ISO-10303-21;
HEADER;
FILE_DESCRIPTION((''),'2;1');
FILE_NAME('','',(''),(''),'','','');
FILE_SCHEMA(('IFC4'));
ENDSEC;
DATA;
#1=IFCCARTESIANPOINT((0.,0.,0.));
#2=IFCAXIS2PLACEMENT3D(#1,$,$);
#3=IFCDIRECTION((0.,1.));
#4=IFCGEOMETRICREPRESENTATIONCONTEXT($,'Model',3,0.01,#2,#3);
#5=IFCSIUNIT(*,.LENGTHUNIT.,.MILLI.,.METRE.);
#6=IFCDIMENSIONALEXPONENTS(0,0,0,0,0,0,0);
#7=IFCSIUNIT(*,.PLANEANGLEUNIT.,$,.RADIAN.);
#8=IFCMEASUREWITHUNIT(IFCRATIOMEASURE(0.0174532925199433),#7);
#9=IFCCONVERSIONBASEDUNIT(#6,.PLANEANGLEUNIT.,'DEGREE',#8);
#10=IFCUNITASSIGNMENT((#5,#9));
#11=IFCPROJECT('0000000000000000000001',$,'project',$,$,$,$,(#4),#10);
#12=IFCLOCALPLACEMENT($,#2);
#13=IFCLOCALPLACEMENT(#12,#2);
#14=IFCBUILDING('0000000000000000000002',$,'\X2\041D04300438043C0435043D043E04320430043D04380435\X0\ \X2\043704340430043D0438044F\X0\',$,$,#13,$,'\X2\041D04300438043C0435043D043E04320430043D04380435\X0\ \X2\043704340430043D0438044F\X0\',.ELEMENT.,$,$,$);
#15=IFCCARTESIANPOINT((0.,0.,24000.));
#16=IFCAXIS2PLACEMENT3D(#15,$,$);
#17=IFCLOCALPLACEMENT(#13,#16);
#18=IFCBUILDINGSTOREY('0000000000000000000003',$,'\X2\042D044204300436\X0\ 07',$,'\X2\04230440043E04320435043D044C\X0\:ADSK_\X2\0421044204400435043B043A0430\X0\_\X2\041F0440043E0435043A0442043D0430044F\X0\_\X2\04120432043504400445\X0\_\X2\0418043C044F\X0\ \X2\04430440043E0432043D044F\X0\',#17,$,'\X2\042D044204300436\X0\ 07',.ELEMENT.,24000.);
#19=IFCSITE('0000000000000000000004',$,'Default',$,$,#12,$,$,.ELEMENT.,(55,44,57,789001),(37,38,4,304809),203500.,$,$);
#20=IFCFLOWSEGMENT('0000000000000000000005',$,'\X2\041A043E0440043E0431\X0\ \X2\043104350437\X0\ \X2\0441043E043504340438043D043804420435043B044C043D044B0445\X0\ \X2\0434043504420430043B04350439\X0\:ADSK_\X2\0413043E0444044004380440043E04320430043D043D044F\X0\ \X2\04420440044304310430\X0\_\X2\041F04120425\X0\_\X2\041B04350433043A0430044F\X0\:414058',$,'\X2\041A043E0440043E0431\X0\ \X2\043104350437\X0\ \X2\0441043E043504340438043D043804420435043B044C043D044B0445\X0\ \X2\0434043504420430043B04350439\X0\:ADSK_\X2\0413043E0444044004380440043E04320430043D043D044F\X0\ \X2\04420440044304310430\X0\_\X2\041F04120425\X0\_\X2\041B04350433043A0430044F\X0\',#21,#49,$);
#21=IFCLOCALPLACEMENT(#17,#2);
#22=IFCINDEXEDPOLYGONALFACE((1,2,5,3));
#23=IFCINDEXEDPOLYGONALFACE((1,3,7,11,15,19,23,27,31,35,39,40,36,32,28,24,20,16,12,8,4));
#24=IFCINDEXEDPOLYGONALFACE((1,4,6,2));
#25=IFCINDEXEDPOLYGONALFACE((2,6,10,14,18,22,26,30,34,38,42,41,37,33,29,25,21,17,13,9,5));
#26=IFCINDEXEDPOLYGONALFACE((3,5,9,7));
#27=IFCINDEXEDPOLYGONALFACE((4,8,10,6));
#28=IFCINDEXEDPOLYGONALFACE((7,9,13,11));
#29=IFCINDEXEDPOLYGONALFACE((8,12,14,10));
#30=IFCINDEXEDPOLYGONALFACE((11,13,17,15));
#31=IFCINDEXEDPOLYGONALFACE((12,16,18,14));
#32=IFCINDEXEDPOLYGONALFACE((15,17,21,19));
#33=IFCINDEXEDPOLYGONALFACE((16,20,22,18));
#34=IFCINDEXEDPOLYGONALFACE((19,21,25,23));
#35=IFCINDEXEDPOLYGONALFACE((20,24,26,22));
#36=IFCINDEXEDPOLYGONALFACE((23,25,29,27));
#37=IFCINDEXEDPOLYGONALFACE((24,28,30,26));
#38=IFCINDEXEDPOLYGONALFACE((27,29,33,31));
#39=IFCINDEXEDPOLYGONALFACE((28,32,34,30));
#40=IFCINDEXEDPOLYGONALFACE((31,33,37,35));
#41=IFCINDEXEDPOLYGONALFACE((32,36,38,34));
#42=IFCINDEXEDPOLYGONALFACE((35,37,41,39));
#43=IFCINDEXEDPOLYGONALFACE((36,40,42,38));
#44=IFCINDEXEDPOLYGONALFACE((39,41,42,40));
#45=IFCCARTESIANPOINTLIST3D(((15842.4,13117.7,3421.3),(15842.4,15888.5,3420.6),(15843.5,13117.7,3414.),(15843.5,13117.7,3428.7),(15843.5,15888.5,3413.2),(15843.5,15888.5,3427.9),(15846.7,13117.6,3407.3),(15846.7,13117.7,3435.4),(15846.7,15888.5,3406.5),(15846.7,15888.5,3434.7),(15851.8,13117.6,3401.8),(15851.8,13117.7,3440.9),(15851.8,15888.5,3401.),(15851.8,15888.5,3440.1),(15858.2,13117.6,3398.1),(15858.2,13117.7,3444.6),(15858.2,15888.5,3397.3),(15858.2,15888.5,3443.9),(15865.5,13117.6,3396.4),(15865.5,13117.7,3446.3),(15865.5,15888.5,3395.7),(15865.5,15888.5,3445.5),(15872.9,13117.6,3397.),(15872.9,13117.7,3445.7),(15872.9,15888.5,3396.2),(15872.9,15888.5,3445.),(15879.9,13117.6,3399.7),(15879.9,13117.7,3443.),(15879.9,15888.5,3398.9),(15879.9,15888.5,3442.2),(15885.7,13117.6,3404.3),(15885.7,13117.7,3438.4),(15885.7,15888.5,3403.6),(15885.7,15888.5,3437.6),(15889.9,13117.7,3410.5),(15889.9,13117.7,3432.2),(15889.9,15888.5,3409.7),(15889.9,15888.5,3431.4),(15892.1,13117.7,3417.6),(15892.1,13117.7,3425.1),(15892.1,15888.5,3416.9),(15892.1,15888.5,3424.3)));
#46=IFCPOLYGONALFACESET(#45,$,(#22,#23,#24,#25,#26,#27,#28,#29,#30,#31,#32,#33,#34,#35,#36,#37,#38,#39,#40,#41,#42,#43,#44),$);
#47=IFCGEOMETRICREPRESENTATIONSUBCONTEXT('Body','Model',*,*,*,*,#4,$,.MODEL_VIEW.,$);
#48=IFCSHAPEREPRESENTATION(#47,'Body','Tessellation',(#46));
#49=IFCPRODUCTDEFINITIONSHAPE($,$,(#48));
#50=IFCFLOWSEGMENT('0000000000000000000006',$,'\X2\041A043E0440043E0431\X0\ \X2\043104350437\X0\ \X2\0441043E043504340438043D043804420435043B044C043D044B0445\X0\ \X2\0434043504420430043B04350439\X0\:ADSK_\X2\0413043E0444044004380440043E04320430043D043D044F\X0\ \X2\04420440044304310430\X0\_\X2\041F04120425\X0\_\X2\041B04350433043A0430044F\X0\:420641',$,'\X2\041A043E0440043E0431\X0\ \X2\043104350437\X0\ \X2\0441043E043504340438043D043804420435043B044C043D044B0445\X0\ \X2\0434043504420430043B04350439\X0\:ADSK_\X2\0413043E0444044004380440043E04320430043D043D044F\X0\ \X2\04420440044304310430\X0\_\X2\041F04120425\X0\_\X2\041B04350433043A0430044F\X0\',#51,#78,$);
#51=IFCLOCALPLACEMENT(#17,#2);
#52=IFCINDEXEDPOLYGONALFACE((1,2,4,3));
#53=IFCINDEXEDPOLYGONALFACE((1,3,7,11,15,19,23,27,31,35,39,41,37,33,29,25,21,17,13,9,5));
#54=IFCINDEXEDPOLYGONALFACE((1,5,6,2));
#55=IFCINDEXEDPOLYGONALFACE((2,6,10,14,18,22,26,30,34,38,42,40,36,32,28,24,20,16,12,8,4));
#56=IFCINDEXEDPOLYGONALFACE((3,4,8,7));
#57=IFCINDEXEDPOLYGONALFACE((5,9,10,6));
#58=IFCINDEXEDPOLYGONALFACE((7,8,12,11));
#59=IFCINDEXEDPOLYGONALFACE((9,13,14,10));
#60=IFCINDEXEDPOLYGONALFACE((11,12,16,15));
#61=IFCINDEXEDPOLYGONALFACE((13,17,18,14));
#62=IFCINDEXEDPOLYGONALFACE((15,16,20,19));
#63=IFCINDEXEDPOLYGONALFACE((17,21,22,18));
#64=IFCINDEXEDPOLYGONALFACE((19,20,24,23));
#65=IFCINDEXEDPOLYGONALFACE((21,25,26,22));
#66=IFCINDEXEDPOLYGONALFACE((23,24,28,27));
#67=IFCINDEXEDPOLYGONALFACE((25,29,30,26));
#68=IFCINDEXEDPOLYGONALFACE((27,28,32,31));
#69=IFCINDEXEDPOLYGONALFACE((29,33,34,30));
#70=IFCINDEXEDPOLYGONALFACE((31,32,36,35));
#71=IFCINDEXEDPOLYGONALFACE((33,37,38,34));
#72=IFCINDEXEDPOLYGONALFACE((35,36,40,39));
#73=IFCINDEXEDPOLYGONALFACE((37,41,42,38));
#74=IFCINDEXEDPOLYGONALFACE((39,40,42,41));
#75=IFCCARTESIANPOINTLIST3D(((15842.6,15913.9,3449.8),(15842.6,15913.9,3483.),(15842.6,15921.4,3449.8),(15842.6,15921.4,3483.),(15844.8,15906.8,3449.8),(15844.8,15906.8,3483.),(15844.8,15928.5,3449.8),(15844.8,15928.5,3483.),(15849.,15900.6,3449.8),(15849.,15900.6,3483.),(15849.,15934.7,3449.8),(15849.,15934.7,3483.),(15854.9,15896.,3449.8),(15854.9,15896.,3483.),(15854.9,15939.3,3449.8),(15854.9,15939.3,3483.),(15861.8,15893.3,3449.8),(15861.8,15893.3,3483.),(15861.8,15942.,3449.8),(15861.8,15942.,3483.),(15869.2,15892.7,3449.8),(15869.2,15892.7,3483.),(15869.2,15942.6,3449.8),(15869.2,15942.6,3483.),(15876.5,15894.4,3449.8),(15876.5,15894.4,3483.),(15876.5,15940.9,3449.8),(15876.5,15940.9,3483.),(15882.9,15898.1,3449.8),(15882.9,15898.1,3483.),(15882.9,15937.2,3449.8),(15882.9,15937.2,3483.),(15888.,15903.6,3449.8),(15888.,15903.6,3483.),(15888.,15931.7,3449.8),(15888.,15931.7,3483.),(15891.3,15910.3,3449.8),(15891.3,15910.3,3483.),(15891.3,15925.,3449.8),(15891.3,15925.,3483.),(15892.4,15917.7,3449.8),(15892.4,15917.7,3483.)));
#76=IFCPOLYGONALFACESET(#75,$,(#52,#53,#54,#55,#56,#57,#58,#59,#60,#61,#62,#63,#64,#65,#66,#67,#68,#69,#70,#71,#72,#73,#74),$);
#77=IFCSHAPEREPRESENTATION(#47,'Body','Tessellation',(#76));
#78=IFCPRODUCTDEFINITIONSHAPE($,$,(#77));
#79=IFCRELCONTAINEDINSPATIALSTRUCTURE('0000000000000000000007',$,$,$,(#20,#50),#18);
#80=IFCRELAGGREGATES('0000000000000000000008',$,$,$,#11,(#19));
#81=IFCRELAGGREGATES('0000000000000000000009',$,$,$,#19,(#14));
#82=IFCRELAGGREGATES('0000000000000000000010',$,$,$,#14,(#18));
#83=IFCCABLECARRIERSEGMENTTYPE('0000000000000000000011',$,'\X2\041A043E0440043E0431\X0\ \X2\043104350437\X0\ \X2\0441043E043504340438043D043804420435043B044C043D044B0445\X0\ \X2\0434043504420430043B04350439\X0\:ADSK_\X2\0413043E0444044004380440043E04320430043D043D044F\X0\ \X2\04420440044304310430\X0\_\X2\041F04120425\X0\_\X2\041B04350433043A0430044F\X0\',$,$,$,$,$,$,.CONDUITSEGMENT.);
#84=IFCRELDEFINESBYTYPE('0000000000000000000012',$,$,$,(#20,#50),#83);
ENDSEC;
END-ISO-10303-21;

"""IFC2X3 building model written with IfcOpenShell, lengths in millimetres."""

from ifc_helpers import new_model, entity, si_unit, converted_unit, direction, frame, frame_2d, origin, place, context, subcontext, project, spatial, circle, extrude, type_object, element, save


model = new_model("IFC2X3")

# Units and contexts
model_context = context("Model", 3, precision=0.01, world=origin(), true_north=direction((0.0, 1.0)))
body_context = subcontext(model_context, "Body", "Model", "MODEL_VIEW")
ifc_project = project(units=[si_unit("LENGTHUNIT", "METRE", prefix="MILLI"), converted_unit("PLANEANGLEUNIT", "DEGREE", entity("IfcRatioMeasure", 0.0174532925199433), si_unit("PLANEANGLEUNIT", "RADIAN"), dimensions=[0, 0, 0, 0, 0, 0, 0])], contexts=[model_context])

# Site, building, storey
site_placement = place(None, frame((0.0, 0.0, 0.0)))
site = spatial("IfcSite", under=ifc_project, at=site_placement, Name="Default", CompositionType="ELEMENT", RefLatitude=(55, 44, 57, 789001), RefLongitude=(37, 38, 4, 304809), RefElevation=203500.0)
building_placement = place(site_placement, origin())
building = spatial("IfcBuilding", under=site, at=building_placement, Name="Наименование здания", LongName="Наименование здания", CompositionType="ELEMENT")
storey_placement = place(building_placement, frame((0.0, 0.0, 24000.0)))
storey = spatial("IfcBuildingStorey", under=building, at=storey_placement, Name="Этаж 07", ObjectType="Уровень:ADSK_Стрелка_Проектная_Вверх_Имя уровня", LongName="Этаж 07", CompositionType="ELEMENT", Elevation=24000.0)

# Flow segments
cable_carrier_segment_type_1 = type_object("IfcCableCarrierSegmentType", Name="Короб без соединительных деталей:ADSK_Гофрировання труба_ПВХ_Легкая", PredefinedType="CONDUITSEGMENT")
flow_segment_1_placement = place(storey_placement, frame((15840.8, 13117.6, 3394.0)))
element("IfcFlowSegment", 1, at=flow_segment_1_placement, inside=storey, type_object=cable_carrier_segment_type_1, Name="Короб без соединительных деталей:ADSK_Гофрировання труба_ПВХ_Легкая:414058", ObjectType="Короб без соединительных деталей:ADSK_Гофрировання труба_ПВХ_Легкая", context=body_context, shape_type="SweptSolid", body=[
    extrude(circle(Radius=25.0, at=frame_2d((0.0, 0.0), x_axis=(1.0, 0.0))), frame((26.6, 2770.8, 26.6), z_axis=(0.0, -1.0, 0.000276), x_axis=(-1.0, 0.0, 0.0)), (0.0, 0.0, 1.0), 2770.8),
])
flow_segment_2_placement = place(storey_placement, frame((15840.8, 15891.1, 3449.8)))
element("IfcFlowSegment", 2, at=flow_segment_2_placement, inside=storey, type_object=cable_carrier_segment_type_1, Name="Короб без соединительных деталей:ADSK_Гофрировання труба_ПВХ_Легкая:420641", ObjectType="Короб без соединительных деталей:ADSK_Гофрировання труба_ПВХ_Легкая", context=body_context, shape_type="SweptSolid", body=[
    extrude(circle(Radius=25.0, at=frame_2d((0.0, 0.0), x_axis=(1.0, 0.0))), frame((26.6, 26.6, 0.0)), (0.0, 0.0, 1.0), 33.2),
])

save(model, "model.ifc")
